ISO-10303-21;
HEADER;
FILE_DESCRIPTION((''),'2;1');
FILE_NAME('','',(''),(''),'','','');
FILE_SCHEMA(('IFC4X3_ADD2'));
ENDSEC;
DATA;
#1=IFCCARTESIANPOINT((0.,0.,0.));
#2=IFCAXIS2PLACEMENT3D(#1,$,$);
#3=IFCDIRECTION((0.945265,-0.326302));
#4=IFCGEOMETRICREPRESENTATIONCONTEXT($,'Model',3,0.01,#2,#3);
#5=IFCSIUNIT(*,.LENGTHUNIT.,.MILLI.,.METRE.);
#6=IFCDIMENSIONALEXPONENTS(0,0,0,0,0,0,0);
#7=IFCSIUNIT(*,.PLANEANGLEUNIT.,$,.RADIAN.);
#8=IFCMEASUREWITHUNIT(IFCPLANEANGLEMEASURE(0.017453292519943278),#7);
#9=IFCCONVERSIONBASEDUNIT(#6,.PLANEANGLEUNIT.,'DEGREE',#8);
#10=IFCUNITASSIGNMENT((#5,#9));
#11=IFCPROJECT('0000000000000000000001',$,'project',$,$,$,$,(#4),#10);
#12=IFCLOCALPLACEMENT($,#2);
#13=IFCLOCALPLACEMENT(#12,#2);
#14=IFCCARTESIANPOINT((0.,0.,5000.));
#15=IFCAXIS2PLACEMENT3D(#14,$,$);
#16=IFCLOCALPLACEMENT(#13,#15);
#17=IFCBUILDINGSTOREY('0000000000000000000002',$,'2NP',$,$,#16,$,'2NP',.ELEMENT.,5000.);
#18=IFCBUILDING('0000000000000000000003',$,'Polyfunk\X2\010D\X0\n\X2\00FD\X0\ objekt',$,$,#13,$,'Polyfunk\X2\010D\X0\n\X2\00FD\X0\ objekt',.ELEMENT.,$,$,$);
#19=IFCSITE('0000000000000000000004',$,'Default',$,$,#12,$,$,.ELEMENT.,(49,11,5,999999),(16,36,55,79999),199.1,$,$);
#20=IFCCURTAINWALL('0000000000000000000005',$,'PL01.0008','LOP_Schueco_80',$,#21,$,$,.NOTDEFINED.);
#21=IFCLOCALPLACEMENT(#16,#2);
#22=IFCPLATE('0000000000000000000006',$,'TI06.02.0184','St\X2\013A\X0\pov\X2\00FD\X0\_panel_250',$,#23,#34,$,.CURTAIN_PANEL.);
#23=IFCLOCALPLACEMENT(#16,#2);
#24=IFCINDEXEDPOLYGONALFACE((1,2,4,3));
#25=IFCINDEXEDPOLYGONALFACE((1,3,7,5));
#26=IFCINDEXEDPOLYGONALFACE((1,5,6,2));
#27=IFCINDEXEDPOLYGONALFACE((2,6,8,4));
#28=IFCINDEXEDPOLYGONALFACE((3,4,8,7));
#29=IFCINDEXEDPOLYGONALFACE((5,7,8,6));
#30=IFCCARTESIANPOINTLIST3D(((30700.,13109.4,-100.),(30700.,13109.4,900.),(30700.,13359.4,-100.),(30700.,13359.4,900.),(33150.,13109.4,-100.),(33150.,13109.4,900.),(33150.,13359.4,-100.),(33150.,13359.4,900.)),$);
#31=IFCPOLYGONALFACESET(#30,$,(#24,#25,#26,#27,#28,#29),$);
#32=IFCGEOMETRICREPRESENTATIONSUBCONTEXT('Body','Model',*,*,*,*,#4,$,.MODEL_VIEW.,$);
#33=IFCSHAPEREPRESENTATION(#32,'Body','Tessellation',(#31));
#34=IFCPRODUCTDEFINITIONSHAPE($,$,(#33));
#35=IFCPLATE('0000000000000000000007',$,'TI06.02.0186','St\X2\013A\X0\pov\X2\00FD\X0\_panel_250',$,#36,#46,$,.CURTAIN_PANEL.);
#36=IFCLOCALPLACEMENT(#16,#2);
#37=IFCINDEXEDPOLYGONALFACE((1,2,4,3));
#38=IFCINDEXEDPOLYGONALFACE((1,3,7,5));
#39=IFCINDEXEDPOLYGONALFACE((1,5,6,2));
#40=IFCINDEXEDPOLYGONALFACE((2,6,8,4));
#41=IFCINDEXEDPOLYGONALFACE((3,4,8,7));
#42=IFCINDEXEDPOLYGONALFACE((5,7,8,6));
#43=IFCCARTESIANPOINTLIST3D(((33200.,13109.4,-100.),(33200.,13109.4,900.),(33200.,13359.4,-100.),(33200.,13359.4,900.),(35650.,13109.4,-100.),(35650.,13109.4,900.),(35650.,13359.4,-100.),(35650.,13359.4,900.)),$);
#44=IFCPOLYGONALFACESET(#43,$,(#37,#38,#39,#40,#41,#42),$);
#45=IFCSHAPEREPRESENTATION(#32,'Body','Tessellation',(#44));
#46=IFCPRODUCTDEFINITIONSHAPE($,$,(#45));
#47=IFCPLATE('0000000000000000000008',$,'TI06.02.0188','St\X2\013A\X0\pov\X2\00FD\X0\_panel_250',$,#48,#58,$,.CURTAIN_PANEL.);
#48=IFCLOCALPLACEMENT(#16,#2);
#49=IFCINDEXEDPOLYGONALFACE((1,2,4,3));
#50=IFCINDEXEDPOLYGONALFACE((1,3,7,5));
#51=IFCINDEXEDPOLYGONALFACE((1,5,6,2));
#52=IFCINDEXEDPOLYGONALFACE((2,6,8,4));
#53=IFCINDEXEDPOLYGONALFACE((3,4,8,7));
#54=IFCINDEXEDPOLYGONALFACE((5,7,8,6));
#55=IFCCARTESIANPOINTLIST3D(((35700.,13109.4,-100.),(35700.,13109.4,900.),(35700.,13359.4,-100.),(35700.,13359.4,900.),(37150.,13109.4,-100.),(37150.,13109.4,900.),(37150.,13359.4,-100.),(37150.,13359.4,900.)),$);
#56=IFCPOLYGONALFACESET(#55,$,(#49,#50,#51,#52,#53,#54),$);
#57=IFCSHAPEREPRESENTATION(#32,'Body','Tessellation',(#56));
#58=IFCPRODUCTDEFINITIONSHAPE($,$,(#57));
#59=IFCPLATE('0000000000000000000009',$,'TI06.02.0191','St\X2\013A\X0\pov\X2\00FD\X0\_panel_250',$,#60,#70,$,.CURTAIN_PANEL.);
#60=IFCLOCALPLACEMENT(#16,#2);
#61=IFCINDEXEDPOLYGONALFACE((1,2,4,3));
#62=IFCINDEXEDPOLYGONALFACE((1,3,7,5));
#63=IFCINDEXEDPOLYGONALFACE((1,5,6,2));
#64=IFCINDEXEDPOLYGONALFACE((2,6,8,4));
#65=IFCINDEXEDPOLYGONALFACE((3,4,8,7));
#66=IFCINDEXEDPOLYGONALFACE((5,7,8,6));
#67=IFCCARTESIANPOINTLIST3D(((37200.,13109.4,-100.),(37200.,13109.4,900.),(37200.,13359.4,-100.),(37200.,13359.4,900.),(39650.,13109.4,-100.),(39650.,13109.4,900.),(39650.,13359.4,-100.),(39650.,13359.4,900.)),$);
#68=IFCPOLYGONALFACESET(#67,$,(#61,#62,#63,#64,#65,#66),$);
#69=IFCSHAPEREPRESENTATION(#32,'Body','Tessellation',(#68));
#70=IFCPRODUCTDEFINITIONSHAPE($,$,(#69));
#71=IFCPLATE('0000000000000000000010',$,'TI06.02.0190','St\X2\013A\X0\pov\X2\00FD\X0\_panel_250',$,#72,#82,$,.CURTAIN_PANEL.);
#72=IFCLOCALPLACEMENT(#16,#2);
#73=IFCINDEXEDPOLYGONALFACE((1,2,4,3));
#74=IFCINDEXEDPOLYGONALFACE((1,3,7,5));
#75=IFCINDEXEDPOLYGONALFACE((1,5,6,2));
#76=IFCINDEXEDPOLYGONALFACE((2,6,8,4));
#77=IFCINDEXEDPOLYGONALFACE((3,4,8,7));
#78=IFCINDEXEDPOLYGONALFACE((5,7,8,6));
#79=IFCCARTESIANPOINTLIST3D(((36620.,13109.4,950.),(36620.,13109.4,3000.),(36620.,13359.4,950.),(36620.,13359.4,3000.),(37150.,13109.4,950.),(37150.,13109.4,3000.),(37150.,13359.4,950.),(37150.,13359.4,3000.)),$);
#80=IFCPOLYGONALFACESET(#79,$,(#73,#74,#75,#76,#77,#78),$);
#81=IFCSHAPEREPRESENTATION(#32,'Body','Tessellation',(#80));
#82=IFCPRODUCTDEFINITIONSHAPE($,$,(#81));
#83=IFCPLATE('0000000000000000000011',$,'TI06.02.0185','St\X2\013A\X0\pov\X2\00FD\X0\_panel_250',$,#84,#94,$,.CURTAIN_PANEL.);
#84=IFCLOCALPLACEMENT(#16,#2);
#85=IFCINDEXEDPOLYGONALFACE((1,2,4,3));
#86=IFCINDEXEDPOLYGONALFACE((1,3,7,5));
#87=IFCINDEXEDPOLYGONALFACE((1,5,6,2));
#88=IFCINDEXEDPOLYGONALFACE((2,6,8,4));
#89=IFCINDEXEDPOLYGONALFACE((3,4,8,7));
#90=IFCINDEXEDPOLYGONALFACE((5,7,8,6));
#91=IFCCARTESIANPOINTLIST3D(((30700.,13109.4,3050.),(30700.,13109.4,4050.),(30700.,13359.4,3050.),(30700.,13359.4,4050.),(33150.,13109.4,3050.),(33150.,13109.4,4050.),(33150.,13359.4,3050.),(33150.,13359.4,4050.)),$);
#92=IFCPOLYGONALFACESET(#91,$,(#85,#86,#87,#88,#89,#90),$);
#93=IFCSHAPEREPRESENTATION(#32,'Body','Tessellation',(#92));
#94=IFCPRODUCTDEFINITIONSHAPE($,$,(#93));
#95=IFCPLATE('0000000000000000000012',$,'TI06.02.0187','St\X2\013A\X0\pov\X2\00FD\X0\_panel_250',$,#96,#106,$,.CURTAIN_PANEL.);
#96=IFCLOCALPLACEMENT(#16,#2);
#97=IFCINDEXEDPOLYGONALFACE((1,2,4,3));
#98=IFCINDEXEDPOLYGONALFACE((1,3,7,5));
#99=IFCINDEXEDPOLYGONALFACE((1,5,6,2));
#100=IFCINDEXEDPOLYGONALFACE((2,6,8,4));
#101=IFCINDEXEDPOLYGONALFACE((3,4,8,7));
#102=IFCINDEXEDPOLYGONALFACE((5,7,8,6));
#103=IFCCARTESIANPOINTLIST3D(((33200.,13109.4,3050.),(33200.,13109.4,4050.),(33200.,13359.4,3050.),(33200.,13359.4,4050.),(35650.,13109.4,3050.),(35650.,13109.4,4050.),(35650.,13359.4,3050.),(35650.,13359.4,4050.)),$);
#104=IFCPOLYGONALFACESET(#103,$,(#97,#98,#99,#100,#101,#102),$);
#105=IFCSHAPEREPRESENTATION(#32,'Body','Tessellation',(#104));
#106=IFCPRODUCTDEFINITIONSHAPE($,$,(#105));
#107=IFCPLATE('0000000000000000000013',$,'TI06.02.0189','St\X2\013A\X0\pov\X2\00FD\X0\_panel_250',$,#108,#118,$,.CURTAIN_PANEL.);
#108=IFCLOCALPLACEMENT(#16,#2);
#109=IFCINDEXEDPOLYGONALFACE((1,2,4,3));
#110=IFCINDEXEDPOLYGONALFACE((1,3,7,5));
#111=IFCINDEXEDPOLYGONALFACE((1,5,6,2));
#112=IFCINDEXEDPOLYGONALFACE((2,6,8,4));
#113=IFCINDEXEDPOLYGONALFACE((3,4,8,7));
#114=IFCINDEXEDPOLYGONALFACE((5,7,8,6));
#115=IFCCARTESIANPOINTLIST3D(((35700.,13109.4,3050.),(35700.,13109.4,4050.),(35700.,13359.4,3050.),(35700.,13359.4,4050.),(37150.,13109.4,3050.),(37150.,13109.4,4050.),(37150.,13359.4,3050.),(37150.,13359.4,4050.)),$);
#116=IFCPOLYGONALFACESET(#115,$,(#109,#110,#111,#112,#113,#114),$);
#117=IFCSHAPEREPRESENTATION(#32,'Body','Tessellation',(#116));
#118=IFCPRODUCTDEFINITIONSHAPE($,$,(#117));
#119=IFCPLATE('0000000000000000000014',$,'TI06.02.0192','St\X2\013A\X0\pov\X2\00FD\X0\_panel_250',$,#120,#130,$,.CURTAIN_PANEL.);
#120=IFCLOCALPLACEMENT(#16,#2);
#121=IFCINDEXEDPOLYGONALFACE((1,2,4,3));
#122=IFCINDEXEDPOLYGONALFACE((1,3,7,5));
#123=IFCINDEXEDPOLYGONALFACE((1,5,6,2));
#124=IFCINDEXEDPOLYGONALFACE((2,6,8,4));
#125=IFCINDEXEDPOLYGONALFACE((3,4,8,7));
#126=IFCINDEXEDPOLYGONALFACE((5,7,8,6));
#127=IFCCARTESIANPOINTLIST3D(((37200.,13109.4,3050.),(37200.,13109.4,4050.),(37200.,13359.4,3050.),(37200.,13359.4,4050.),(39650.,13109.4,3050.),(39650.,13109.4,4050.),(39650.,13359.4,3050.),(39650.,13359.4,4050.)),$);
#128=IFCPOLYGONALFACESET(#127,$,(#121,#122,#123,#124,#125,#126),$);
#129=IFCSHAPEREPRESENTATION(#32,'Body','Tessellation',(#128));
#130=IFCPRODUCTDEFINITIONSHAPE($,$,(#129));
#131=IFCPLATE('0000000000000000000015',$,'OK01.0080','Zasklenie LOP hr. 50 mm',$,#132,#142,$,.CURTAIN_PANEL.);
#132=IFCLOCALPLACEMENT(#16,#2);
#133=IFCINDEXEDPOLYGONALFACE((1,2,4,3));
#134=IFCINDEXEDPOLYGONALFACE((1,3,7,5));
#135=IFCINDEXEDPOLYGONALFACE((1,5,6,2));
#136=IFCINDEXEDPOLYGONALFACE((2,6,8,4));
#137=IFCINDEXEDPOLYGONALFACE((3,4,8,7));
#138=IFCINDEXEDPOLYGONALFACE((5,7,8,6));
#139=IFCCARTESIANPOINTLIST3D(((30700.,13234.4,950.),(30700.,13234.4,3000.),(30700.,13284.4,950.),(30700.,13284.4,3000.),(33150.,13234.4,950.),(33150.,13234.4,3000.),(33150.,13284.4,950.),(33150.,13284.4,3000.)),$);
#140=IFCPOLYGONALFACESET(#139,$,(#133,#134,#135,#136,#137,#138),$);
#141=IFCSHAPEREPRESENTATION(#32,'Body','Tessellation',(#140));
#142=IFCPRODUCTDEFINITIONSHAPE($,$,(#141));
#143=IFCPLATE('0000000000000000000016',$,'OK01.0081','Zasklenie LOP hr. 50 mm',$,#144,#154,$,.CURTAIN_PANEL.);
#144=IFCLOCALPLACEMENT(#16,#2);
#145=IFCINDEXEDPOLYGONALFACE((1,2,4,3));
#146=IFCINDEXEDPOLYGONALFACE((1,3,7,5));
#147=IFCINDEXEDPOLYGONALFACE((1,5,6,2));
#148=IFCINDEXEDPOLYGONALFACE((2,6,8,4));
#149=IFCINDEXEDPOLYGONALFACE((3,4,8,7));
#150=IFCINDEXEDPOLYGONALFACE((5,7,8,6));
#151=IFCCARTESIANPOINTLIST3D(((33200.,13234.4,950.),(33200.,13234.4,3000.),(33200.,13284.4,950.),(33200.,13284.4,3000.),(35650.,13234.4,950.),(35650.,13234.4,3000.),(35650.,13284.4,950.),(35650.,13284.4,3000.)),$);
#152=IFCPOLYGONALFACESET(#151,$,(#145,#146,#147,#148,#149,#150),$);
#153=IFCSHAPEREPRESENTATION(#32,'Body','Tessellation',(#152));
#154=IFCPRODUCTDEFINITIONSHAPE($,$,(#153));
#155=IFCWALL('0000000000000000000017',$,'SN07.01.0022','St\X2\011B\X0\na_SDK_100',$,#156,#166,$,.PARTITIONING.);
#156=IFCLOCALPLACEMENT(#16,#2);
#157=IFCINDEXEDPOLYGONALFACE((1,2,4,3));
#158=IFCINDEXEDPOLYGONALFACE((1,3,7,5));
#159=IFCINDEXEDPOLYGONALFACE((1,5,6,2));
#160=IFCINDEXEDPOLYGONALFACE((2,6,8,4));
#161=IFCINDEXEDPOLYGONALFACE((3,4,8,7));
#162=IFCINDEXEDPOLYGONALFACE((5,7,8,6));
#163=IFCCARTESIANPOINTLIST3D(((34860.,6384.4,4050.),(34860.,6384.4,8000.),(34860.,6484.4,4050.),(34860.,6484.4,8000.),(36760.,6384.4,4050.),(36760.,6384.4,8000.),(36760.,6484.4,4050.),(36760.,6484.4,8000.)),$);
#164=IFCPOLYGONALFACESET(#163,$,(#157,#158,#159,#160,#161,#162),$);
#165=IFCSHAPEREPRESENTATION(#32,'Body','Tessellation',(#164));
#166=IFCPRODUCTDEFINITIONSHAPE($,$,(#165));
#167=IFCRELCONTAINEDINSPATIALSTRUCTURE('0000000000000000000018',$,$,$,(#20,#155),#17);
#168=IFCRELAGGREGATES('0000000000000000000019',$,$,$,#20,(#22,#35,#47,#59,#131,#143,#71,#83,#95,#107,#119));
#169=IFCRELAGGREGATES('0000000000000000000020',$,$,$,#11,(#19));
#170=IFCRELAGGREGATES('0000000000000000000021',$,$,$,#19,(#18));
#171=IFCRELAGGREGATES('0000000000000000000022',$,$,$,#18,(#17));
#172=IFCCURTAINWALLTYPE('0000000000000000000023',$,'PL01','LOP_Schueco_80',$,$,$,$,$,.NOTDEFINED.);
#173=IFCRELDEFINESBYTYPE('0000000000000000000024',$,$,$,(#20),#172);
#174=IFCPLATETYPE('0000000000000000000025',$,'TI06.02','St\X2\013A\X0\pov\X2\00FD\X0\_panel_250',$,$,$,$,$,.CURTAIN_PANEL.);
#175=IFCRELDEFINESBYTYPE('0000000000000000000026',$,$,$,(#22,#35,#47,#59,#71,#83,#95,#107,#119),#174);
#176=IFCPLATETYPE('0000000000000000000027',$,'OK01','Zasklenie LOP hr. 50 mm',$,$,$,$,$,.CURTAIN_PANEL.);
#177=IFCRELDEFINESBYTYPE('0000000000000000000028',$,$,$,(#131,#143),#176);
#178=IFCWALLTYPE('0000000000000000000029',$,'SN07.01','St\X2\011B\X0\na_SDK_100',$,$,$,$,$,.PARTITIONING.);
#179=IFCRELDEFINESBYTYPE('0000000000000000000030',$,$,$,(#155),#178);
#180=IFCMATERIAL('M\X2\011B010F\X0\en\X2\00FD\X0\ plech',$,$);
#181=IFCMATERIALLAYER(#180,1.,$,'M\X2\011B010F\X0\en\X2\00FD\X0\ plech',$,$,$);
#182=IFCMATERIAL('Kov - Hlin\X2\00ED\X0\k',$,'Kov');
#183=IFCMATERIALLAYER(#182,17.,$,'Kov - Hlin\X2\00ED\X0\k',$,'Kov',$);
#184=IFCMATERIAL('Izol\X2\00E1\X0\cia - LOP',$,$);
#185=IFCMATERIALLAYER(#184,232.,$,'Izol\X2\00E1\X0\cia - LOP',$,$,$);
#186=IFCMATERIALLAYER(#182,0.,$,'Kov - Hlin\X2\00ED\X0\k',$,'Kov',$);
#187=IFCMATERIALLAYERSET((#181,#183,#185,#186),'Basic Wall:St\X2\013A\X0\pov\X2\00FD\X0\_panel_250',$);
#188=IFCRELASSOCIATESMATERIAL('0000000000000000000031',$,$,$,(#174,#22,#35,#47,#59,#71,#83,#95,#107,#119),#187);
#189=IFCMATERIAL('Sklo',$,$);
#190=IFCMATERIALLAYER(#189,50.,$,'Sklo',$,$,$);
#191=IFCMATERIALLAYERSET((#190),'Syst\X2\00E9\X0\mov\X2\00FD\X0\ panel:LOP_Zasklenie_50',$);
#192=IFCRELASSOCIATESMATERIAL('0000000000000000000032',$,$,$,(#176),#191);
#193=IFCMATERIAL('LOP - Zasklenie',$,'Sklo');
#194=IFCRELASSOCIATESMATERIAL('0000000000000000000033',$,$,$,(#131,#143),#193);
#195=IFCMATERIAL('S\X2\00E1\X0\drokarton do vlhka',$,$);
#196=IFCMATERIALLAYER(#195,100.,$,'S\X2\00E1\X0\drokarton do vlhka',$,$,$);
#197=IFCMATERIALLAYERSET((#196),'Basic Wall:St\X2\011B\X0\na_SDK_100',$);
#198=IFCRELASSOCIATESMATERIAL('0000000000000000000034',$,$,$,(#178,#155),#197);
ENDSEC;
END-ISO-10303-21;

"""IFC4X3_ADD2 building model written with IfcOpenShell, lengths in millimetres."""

from ifc_helpers import new_model, entity, si_unit, converted_unit, direction, frame, frame_2d, origin, origin_2d_with_axis, place, context, subcontext, project, spatial, polyline, rectangle, extrude, clip, bounded_halfspace, source, transform, mapped, material, layer, layer_set, layer_usage, type_object, type_shapes, element, aggregate, save


model = new_model("IFC4X3_ADD2")

# Units and contexts
model_context = context("Model", 3, precision=0.01, world=origin(), true_north=direction((0.945265, -0.326302)))
body_context = subcontext(model_context, "Body", "Model", "MODEL_VIEW")
ifc_project = project(units=[si_unit("LENGTHUNIT", "METRE", prefix="MILLI"), converted_unit("PLANEANGLEUNIT", "DEGREE", entity("IfcPlaneAngleMeasure", 0.017453292519943278), si_unit("PLANEANGLEUNIT", "RADIAN"), dimensions=[0, 0, 0, 0, 0, 0, 0])], contexts=[model_context])

# Site, building, storey
site_placement = place(None, origin())
site = spatial("IfcSite", under=ifc_project, at=site_placement, Name="Default", CompositionType="ELEMENT", RefLatitude=(49, 11, 5, 999999), RefLongitude=(16, 36, 55, 79999), RefElevation=199.1)
building_placement = place(site_placement, origin())
building = spatial("IfcBuilding", under=site, at=building_placement, Name="Polyfunkčný objekt", LongName="Polyfunkčný objekt", CompositionType="ELEMENT")
storey_placement = place(building_placement, frame((0.0, 0.0, 5000.0)))
storey = spatial("IfcBuildingStorey", under=building, at=storey_placement, Name="2NP", LongName="2NP", CompositionType="ELEMENT", Elevation=5000.0)

# Curtain wall, plates
curtain_wall_type = type_object("IfcCurtainWallType", Name="PL01", Description="LOP_Schueco_80", PredefinedType="NOTDEFINED")
curtain_wall_placement = place(storey_placement, frame((0.0, 0.0, -5000.0)))
curtain_wall = element("IfcCurtainWall", 1, at=curtain_wall_placement, inside=storey, type_object=curtain_wall_type, Name="PL01.0008", Description="LOP_Schueco_80", PredefinedType="NOTDEFINED")
ifc_material_1 = material(Name="Měďený plech")
ifc_layer_1 = layer(ifc_material_1, 1.0, Name="Měďený plech")
ifc_material_2 = material(Name="Kov - Hliník", Category="Kov")
ifc_layer_2 = layer(ifc_material_2, 17.0, Name="Kov - Hliník", Category="Kov")
ifc_material_3 = material(Name="Izolácia - LOP")
ifc_layer_3 = layer(ifc_material_3, 232.0, Name="Izolácia - LOP")
ifc_layer_4 = layer(ifc_material_2, 0.0, Name="Kov - Hliník", Category="Kov")
ifc_layer_set_1 = layer_set([ifc_layer_1, ifc_layer_2, ifc_layer_3, ifc_layer_4], Name="Basic Wall:Stĺpový_panel_250")
ifc_layer_usage_1 = layer_usage(ifc_layer_set_1, "AXIS2", "NEGATIVE", 125.0)
plate_type_1 = type_object("IfcPlateType", Name="TI06.02", Description="Stĺpový_panel_250", PredefinedType="CURTAIN_PANEL", material=ifc_layer_set_1)
plate_1_placement = place(storey_placement, frame((30700.0, 13234.4, -100.0)))
plate_1 = element("IfcPlate", 2, at=plate_1_placement, type_object=plate_type_1, material=ifc_layer_usage_1, Name="TI06.02.0184", Description="Stĺpový_panel_250", PredefinedType="CURTAIN_PANEL", context=body_context, shape_type="SweptSolid", body=[
    extrude(rectangle(XDim=250.0, YDim=2450.0, at=frame_2d((0.0, 0.0), x_axis=(1.0, 0.0))), frame((1225.0, 0.0, 0.0), z_axis=(0.0, 0.0, 1.0), x_axis=(0.0, 1.0, 0.0)), (0.0, 0.0, 1.0), 1000.0),
])
ifc_layer_usage_2 = layer_usage(ifc_layer_set_1, "AXIS2", "NEGATIVE", 125.0)
plate_2_placement = place(storey_placement, frame((33200.0, 13234.4, -100.0)))
plate_2 = element("IfcPlate", 3, at=plate_2_placement, type_object=plate_type_1, material=ifc_layer_usage_2, Name="TI06.02.0186", Description="Stĺpový_panel_250", PredefinedType="CURTAIN_PANEL", context=body_context, shape_type="SweptSolid", body=[
    extrude(rectangle(XDim=250.0, YDim=2450.0, at=frame_2d((0.0, 0.0), x_axis=(1.0, 0.0))), frame((1225.0, 0.0, 0.0), z_axis=(0.0, 0.0, 1.0), x_axis=(0.0, 1.0, 0.0)), (0.0, 0.0, 1.0), 1000.0),
])
ifc_layer_usage_3 = layer_usage(ifc_layer_set_1, "AXIS2", "NEGATIVE", 125.0)
plate_3_placement = place(storey_placement, frame((35700.0, 13234.4, -100.0)))
plate_3 = element("IfcPlate", 4, at=plate_3_placement, type_object=plate_type_1, material=ifc_layer_usage_3, Name="TI06.02.0188", Description="Stĺpový_panel_250", PredefinedType="CURTAIN_PANEL", context=body_context, shape_type="SweptSolid", body=[
    extrude(rectangle(XDim=250.0, YDim=1450.0, at=origin_2d_with_axis()), frame((725.0, 0.0, 0.0), z_axis=(0.0, 0.0, 1.0), x_axis=(0.0, 1.0, 0.0)), (0.0, 0.0, 1.0), 1000.0),
])
ifc_layer_usage_4 = layer_usage(ifc_layer_set_1, "AXIS2", "NEGATIVE", 125.0)
plate_4_placement = place(storey_placement, frame((37200.0, 13234.4, -100.0)))
plate_4 = element("IfcPlate", 5, at=plate_4_placement, type_object=plate_type_1, material=ifc_layer_usage_4, Name="TI06.02.0191", Description="Stĺpový_panel_250", PredefinedType="CURTAIN_PANEL", context=body_context, shape_type="SweptSolid", body=[
    extrude(rectangle(XDim=250.0, YDim=2450.0, at=frame_2d((0.0, 0.0), x_axis=(1.0, 0.0))), frame((1225.0, 0.0, 0.0), z_axis=(0.0, 0.0, 1.0), x_axis=(0.0, 1.0, 0.0)), (0.0, 0.0, 1.0), 1000.0),
])
ifc_layer_usage_5 = layer_usage(ifc_layer_set_1, "AXIS2", "NEGATIVE", 125.0)
plate_5_placement = place(storey_placement, frame((36620.0, 13234.4, 950.0)))
plate_5 = element("IfcPlate", 6, at=plate_5_placement, type_object=plate_type_1, material=ifc_layer_usage_5, Name="TI06.02.0190", Description="Stĺpový_panel_250", PredefinedType="CURTAIN_PANEL", context=body_context, shape_type="SweptSolid", body=[
    extrude(rectangle(XDim=250.0, YDim=530.0, at=frame_2d((0.0, 0.0), x_axis=(1.0, 0.0))), frame((265.0, 0.0, 0.0), z_axis=(0.0, 0.0, 1.0), x_axis=(0.0, 1.0, 0.0)), (0.0, 0.0, 1.0), 2050.0),
])
ifc_layer_usage_6 = layer_usage(ifc_layer_set_1, "AXIS2", "NEGATIVE", 125.0)
plate_6_placement = place(storey_placement, frame((30700.0, 13234.4, 3050.0)))
plate_6 = element("IfcPlate", 7, at=plate_6_placement, type_object=plate_type_1, material=ifc_layer_usage_6, Name="TI06.02.0185", Description="Stĺpový_panel_250", PredefinedType="CURTAIN_PANEL", context=body_context, shape_type="SweptSolid", body=[
    extrude(rectangle(XDim=250.0, YDim=2450.0, at=frame_2d((0.0, 0.0), x_axis=(1.0, 0.0))), frame((1225.0, 0.0, 0.0), z_axis=(0.0, 0.0, 1.0), x_axis=(0.0, 1.0, 0.0)), (0.0, 0.0, 1.0), 1000.0),
])
ifc_layer_usage_7 = layer_usage(ifc_layer_set_1, "AXIS2", "NEGATIVE", 125.0)
plate_7_placement = place(storey_placement, frame((33200.0, 13234.4, 3050.0)))
plate_7 = element("IfcPlate", 8, at=plate_7_placement, type_object=plate_type_1, material=ifc_layer_usage_7, Name="TI06.02.0187", Description="Stĺpový_panel_250", PredefinedType="CURTAIN_PANEL", context=body_context, shape_type="SweptSolid", body=[
    extrude(rectangle(XDim=250.0, YDim=2450.0, at=frame_2d((0.0, 0.0), x_axis=(1.0, 0.0))), frame((1225.0, 0.0, 0.0), z_axis=(0.0, 0.0, 1.0), x_axis=(0.0, 1.0, 0.0)), (0.0, 0.0, 1.0), 1000.0),
])
ifc_layer_usage_8 = layer_usage(ifc_layer_set_1, "AXIS2", "NEGATIVE", 125.0)
plate_8_placement = place(storey_placement, frame((35700.0, 13234.4, 3050.0)))
plate_8 = element("IfcPlate", 9, at=plate_8_placement, type_object=plate_type_1, material=ifc_layer_usage_8, Name="TI06.02.0189", Description="Stĺpový_panel_250", PredefinedType="CURTAIN_PANEL", context=body_context, shape_type="SweptSolid", body=[
    extrude(rectangle(XDim=250.0, YDim=1450.0, at=origin_2d_with_axis()), frame((725.0, 0.0, 0.0), z_axis=(0.0, 0.0, 1.0), x_axis=(0.0, 1.0, 0.0)), (0.0, 0.0, 1.0), 1000.0),
])
ifc_layer_usage_9 = layer_usage(ifc_layer_set_1, "AXIS2", "NEGATIVE", 125.0)
plate_9_placement = place(storey_placement, frame((37200.0, 13234.4, 3050.0)))
plate_9 = element("IfcPlate", 10, at=plate_9_placement, type_object=plate_type_1, material=ifc_layer_usage_9, Name="TI06.02.0192", Description="Stĺpový_panel_250", PredefinedType="CURTAIN_PANEL", context=body_context, shape_type="SweptSolid", body=[
    extrude(rectangle(XDim=250.0, YDim=2450.0, at=frame_2d((0.0, 0.0), x_axis=(1.0, 0.0))), frame((1225.0, 0.0, 0.0), z_axis=(0.0, 0.0, 1.0), x_axis=(0.0, 1.0, 0.0)), (0.0, 0.0, 1.0), 1000.0),
])
ifc_material_4 = material(Name="LOP - Zasklenie", Category="Sklo")
ifc_material_5 = material(Name="Sklo")
ifc_layer_5 = layer(ifc_material_5, 50.0, Name="Sklo")
ifc_layer_set_2 = layer_set([ifc_layer_5], Name="Systémový panel:LOP_Zasklenie_50")
plate_type_2 = type_object("IfcPlateType", Name="OK01", Description="Zasklenie LOP hr. 50 mm", PredefinedType="CURTAIN_PANEL", material=ifc_layer_set_2)
shared_shape_1 = source(origin(), body_context, "Body", "SweptSolid", [
    extrude(rectangle(XDim=50.0, YDim=2450.0, at=origin_2d_with_axis()), frame((0.0, 25.0, 0.0), z_axis=(0.0, 0.0, 1.0), x_axis=(0.0, 1.0, 0.0)), (0.0, 0.0, 1.0), 2050.0),
])
type_shapes(plate_type_2, [shared_shape_1])
plate_10_placement = place(curtain_wall_placement, frame((31925.0, 13234.4, 5950.0)))
plate_10 = element("IfcPlate", 11, at=plate_10_placement, type_object=plate_type_2, material=ifc_material_4, Name="OK01.0080", Description="Zasklenie LOP hr. 50 mm", PredefinedType="CURTAIN_PANEL", context=body_context, shape_type="MappedRepresentation", body=[
    mapped(shared_shape_1, transform((0.0, 0.0, 0.0), scale=1.0)),
])
plate_11_placement = place(curtain_wall_placement, frame((34425.0, 13234.4, 5950.0)))
plate_11 = element("IfcPlate", 12, at=plate_11_placement, type_object=plate_type_2, material=ifc_material_4, Name="OK01.0081", Description="Zasklenie LOP hr. 50 mm", PredefinedType="CURTAIN_PANEL", context=body_context, shape_type="MappedRepresentation", body=[
    mapped(shared_shape_1, transform((0.0, 0.0, 0.0), scale=1.0)),
])

# Wall
ifc_material_6 = material(Name="Sádrokarton do vlhka")
ifc_layer_6 = layer(ifc_material_6, 100.0, Name="Sádrokarton do vlhka")
ifc_layer_set_3 = layer_set([ifc_layer_6], Name="Basic Wall:Stěna_SDK_100")
wall_type_1 = type_object("IfcWallType", Name="SN07.01", Description="Stěna_SDK_100", PredefinedType="PARTITIONING", material=ifc_layer_set_3)
wall_1_placement = place(storey_placement, frame((36760.0, 6434.4, 4050.0), z_axis=(0.0, 0.0, 1.0), x_axis=(-1.0, 0.0, 0.0)))
element("IfcWall", 13, at=wall_1_placement, inside=storey, type_object=wall_type_1, material=ifc_layer_set_3, Name="SN07.01.0022", Description="Stěna_SDK_100", PredefinedType="PARTITIONING", context=body_context, shape_type="Clipping", body=[
    clip(clip(extrude(rectangle(XDim=1900.0, YDim=100.0, at=frame_2d((950.0, 0.0), x_axis=(-1.0, 0.0))), origin(), (0.0, 0.0, 1.0), 3950.0), bounded_halfspace(frame((1900.0, -50.0, 0.0)), True, frame((1900.0, -50.0, 0.0)), polyline([(0.0, 0.0), (0.0, 100.0), (-1750.0, 100.0), (-1900.0, 100.0), (-1900.0, 0.0), (0.0, 0.0)]))), bounded_halfspace(frame((0.0, -50.0, 3950.0), z_axis=(0.0, 0.0, -1.0), x_axis=(-1.0, 0.0, 0.0)), True, frame((0.0, -50.0, 3950.0)), polyline([(0.0, 0.0), (1900.0, 0.0), (1900.0, 100.0), (150.0, 100.0), (0.0, 100.0), (0.0, 0.0)]))),
])

aggregate(curtain_wall, [plate_1, plate_2, plate_3, plate_4, plate_10, plate_11, plate_5, plate_6, plate_7, plate_8, plate_9])

save(model, "model.ifc")
